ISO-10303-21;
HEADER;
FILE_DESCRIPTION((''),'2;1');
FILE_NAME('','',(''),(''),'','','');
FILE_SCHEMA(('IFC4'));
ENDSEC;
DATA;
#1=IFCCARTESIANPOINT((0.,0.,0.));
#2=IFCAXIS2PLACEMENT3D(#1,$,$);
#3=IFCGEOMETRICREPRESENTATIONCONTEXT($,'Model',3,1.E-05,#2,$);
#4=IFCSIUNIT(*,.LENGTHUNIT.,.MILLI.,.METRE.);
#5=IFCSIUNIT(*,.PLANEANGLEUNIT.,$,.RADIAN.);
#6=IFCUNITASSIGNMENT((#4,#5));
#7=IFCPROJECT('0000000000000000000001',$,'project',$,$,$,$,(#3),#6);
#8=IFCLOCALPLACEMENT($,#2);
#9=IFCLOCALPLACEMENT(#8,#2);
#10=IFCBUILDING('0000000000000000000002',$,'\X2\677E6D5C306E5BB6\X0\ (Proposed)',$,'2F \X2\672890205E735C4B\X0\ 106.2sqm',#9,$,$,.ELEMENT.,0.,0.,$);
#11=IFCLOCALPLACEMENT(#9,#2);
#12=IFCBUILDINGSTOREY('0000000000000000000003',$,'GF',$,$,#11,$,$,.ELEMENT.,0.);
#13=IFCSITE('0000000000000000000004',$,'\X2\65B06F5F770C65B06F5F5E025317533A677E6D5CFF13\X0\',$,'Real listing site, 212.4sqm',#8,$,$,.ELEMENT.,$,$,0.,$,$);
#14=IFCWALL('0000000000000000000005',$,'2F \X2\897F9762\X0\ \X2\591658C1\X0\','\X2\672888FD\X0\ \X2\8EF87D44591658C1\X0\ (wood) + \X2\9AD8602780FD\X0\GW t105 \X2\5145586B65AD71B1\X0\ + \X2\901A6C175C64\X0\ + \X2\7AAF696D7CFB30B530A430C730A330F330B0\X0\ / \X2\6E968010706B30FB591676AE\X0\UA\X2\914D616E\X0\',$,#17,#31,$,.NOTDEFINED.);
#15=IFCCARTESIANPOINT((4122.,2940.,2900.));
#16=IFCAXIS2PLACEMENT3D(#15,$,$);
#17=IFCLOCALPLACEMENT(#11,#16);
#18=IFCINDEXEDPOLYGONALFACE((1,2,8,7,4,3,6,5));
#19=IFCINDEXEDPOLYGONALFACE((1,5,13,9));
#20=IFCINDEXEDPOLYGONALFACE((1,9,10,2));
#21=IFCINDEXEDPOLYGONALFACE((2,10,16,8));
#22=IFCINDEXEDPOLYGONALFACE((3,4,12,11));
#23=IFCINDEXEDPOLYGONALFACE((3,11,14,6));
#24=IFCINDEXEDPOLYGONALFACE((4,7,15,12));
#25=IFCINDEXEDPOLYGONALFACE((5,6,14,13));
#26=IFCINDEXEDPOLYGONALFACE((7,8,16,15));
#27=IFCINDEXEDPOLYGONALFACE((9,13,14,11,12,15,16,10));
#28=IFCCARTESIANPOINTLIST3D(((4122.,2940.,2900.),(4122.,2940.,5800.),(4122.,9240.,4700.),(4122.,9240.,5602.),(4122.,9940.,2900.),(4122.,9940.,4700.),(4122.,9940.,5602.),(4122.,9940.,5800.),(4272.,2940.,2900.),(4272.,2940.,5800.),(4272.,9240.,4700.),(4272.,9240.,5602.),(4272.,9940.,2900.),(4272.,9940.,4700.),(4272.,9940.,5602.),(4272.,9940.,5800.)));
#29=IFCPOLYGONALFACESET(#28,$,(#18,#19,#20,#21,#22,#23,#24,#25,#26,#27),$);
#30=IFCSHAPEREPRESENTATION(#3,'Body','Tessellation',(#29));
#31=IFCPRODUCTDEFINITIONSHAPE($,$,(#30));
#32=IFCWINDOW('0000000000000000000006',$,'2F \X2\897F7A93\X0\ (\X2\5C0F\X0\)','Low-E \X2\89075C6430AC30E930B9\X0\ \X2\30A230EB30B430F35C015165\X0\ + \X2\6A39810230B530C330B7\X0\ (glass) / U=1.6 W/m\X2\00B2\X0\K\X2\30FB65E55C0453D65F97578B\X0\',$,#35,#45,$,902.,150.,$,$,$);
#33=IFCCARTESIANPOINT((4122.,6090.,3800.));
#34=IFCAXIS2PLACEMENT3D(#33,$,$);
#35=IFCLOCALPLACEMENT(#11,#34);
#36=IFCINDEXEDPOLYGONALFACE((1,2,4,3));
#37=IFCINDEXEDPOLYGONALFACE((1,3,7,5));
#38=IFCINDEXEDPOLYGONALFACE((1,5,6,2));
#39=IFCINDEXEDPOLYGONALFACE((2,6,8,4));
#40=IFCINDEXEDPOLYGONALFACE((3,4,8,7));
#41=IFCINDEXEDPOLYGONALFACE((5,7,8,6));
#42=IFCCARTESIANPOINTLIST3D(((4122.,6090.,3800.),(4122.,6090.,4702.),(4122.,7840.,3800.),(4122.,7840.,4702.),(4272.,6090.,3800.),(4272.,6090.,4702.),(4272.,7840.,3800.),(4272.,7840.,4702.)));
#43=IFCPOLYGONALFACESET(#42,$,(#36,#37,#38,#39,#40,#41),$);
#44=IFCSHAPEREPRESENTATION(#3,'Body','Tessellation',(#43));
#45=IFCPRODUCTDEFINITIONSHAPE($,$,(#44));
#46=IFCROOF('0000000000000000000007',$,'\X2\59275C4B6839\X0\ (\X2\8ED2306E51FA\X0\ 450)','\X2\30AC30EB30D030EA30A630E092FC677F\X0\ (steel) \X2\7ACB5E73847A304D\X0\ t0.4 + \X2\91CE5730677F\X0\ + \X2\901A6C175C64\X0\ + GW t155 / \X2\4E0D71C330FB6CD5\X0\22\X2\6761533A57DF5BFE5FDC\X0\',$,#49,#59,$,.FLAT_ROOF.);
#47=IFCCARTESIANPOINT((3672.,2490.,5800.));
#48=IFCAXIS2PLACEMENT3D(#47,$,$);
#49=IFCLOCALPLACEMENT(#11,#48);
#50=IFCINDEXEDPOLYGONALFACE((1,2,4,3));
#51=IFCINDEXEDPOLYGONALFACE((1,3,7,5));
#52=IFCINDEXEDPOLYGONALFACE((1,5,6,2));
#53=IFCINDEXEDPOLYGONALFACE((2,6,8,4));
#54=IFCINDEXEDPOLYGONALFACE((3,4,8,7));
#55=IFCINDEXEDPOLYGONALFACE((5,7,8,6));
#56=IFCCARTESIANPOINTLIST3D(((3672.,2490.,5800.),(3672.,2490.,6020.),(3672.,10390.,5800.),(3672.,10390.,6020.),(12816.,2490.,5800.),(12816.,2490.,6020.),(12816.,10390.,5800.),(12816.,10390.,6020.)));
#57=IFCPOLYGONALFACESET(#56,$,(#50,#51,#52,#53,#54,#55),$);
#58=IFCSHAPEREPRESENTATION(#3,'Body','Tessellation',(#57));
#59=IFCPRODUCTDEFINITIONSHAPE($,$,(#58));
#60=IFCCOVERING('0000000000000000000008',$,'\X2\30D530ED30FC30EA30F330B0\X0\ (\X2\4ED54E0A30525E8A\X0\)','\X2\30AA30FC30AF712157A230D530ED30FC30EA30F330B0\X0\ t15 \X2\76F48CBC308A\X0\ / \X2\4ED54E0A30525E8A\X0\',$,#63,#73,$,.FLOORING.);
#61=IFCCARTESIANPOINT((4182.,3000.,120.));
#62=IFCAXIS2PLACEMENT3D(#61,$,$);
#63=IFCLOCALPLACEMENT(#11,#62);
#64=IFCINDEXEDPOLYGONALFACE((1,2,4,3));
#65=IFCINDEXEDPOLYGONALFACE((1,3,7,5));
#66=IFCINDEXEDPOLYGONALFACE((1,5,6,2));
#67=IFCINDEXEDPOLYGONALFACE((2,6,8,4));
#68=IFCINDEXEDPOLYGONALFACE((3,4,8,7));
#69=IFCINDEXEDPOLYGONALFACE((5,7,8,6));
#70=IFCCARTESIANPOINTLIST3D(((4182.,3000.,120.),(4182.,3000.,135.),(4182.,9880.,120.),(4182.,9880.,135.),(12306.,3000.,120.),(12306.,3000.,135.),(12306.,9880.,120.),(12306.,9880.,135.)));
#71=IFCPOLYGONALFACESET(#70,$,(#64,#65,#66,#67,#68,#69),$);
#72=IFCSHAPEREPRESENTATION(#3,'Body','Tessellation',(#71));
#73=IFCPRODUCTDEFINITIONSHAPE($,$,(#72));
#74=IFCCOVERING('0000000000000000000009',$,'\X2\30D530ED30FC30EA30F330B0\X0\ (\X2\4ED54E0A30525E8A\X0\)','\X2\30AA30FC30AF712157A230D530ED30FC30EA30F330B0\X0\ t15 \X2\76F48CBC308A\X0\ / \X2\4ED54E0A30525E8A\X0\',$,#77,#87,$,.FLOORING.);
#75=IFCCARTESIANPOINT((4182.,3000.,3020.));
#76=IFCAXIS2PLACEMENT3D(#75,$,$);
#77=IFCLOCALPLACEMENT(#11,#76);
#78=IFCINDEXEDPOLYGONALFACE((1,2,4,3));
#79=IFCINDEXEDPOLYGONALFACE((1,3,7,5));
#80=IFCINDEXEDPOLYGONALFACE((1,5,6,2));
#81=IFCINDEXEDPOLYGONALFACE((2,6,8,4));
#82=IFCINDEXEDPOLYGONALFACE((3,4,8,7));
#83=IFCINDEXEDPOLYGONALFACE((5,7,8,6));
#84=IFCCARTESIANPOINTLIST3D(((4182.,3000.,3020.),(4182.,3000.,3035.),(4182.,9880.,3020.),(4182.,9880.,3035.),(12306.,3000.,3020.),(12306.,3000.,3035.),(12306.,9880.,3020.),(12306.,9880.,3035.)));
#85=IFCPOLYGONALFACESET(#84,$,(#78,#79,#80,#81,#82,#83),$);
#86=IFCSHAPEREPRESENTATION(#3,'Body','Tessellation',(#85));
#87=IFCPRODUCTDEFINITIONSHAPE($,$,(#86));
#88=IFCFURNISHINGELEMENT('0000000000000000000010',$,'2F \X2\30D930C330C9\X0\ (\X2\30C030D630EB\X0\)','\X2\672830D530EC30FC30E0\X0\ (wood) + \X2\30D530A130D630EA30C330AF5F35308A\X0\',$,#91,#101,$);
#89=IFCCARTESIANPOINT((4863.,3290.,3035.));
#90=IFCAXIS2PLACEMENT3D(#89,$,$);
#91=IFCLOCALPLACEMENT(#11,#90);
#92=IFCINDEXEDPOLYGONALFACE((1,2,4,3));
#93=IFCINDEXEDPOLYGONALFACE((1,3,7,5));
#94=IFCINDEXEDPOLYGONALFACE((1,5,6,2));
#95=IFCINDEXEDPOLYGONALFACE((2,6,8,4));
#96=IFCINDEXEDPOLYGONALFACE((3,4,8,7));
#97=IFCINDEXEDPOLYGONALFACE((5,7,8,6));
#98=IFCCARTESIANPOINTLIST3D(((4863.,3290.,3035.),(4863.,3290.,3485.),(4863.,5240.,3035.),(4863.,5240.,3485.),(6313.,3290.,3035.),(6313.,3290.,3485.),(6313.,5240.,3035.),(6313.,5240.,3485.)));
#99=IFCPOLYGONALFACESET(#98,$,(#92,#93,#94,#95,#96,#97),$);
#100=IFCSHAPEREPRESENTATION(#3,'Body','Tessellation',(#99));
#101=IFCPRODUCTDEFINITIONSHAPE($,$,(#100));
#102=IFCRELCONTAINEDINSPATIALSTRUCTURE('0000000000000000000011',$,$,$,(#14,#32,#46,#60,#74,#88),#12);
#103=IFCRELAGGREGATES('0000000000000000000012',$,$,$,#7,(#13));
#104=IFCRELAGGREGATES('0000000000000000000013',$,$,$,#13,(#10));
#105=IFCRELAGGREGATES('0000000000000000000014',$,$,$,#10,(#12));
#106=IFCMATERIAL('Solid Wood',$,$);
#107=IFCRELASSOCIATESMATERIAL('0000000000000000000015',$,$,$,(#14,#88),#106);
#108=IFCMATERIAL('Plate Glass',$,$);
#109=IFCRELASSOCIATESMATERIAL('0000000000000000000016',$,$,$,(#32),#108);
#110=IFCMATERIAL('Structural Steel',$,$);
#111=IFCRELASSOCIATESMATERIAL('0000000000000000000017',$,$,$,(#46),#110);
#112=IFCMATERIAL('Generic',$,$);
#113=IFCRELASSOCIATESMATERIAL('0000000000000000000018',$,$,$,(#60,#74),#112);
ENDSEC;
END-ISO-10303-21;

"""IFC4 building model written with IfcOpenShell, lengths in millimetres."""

from ifc_helpers import new_model, si_unit, frame, frame_2d, origin, place, context, project, spatial, rectangle, extrude, material, element, fill, save


model = new_model("IFC4")

# Units and contexts
model_context = context("Model", 3, precision=1e-05, world=origin())
ifc_project = project(units=[si_unit("LENGTHUNIT", "METRE", prefix="MILLI"), si_unit("PLANEANGLEUNIT", "RADIAN")], contexts=[model_context])

# Site, building, storey
site_placement = place(None, origin())
site = spatial("IfcSite", under=ifc_project, at=site_placement, Name="新潟県新潟市北区松浜３", ObjectType="Real listing site, 212.4sqm", CompositionType="ELEMENT", RefElevation=0.0)
building_placement = place(site_placement, origin())
building = spatial("IfcBuilding", under=site, at=building_placement, Name="松浜の家 (Proposed)", ObjectType="2F 木造平屋 106.2sqm", CompositionType="ELEMENT", ElevationOfRefHeight=0.0, ElevationOfTerrain=0.0)
storey_placement = place(building_placement, origin())
storey = spatial("IfcBuildingStorey", under=building, at=storey_placement, Name="GF", CompositionType="ELEMENT", Elevation=0.0)

# Shared definitions
ifc_material_1 = material(Name="Solid Wood")

# Shared definitions
ifc_material_2 = material(Name="Plate Glass")

# Wall, opening, window
wall_1_placement = place(storey_placement, frame((4122.0, 2940.0, 2900.0)))
wall_1 = element("IfcWall", 1, at=wall_1_placement, inside=storey, material=ifc_material_1, Name="2F 西面 外壁", Description="木製 軸組外壁 (wood) + 高性能GW t105 充填断熱 + 通気層 + 窯業系サイディング / 準耐火・外皮UA配慮", PredefinedType="NOTDEFINED", context=model_context, shape_type="SweptSolid", body=[
    extrude(rectangle(XDim=150.0, YDim=7000.0, at=frame_2d((75.0, 3500.0))), frame((4122.0, 2940.0, 2900.0)), (0.0, 0.0, 1.0), 2900.0),
])
opening_1_placement = place(storey_placement, frame((4122.0, 6090.0, 3800.0)))
opening_1 = element("IfcOpeningElement", 2, at=opening_1_placement, cuts=wall_1, PredefinedType="NOTDEFINED", context=model_context, shape_type="SweptSolid", body=[
    extrude(rectangle(XDim=150.0, YDim=1750.0, at=frame_2d((75.0, 875.0))), frame((4122.0, 6090.0, 3800.0)), (0.0, 0.0, 1.0), 902.0),
])
window_1_placement = place(storey_placement, frame((4122.0, 6090.0, 3800.0)))
window_1 = element("IfcWindow", 3, at=window_1_placement, inside=storey, material=ifc_material_2, Name="2F 西窓 (小)", Description="Low-E 複層ガラス アルゴン封入 + 樹脂サッシ (glass) / U=1.6 W/m²K・日射取得型", OverallHeight=902.0, OverallWidth=150.0, context=model_context, shape_type="SweptSolid", body=[
    extrude(rectangle(XDim=150.0, YDim=1750.0, at=frame_2d((75.0, 875.0))), frame((4122.0, 6090.0, 3800.0)), (0.0, 0.0, 1.0), 902.0),
])
fill(opening_1, window_1)

# Roof
ifc_material_3 = material(Name="Structural Steel")
roof_placement = place(storey_placement, frame((3672.0, 2490.0, 5800.0)))
element("IfcRoof", 4, at=roof_placement, inside=storey, material=ifc_material_3, Name="大屋根 (軒の出 450)", Description="ガルバリウム鋼板 (steel) 立平葺き t0.4 + 野地板 + 通気層 + GW t155 / 不燃・法22条区域対応", PredefinedType="FLAT_ROOF", context=model_context, shape_type="SweptSolid", body=[
    extrude(rectangle(XDim=9144.0, YDim=7900.0, at=frame_2d((4572.0, 3950.0))), frame((3672.0, 2490.0, 5800.0)), (0.0, 0.0, 1.0), 220.0),
])

# Coverings
ifc_material_4 = material(Name="Generic")
covering_1_placement = place(storey_placement, frame((4182.0, 3000.0, 120.0)))
element("IfcCovering", 5, at=covering_1_placement, inside=storey, material=ifc_material_4, Name="フローリング (仕上げ床)", Description="オーク無垢フローリング t15 直貼り / 仕上げ床", PredefinedType="FLOORING", context=model_context, shape_type="SweptSolid", body=[
    extrude(rectangle(XDim=8124.0, YDim=6880.0, at=frame_2d((4062.0, 3440.0))), frame((4182.0, 3000.0, 120.0)), (0.0, 0.0, 1.0), 15.0),
])
covering_2_placement = place(storey_placement, frame((4182.0, 3000.0, 3020.0)))
element("IfcCovering", 6, at=covering_2_placement, inside=storey, material=ifc_material_4, Name="フローリング (仕上げ床)", Description="オーク無垢フローリング t15 直貼り / 仕上げ床", PredefinedType="FLOORING", context=model_context, shape_type="SweptSolid", body=[
    extrude(rectangle(XDim=8124.0, YDim=6880.0, at=frame_2d((4062.0, 3440.0))), frame((4182.0, 3000.0, 3020.0)), (0.0, 0.0, 1.0), 15.0),
])

# Furnishing element
furnishing_placement = place(storey_placement, frame((4863.0, 3290.0, 3035.0)))
element("IfcFurnishingElement", 7, at=furnishing_placement, inside=storey, material=ifc_material_1, Name="2F ベッド (ダブル)", Description="木フレーム (wood) + ファブリック張り", context=model_context, shape_type="SweptSolid", body=[
    extrude(rectangle(XDim=1450.0, YDim=1950.0, at=frame_2d((725.0, 975.0))), frame((4863.0, 3290.0, 3035.0)), (0.0, 0.0, 1.0), 450.0),
])

save(model, "model.ifc")
